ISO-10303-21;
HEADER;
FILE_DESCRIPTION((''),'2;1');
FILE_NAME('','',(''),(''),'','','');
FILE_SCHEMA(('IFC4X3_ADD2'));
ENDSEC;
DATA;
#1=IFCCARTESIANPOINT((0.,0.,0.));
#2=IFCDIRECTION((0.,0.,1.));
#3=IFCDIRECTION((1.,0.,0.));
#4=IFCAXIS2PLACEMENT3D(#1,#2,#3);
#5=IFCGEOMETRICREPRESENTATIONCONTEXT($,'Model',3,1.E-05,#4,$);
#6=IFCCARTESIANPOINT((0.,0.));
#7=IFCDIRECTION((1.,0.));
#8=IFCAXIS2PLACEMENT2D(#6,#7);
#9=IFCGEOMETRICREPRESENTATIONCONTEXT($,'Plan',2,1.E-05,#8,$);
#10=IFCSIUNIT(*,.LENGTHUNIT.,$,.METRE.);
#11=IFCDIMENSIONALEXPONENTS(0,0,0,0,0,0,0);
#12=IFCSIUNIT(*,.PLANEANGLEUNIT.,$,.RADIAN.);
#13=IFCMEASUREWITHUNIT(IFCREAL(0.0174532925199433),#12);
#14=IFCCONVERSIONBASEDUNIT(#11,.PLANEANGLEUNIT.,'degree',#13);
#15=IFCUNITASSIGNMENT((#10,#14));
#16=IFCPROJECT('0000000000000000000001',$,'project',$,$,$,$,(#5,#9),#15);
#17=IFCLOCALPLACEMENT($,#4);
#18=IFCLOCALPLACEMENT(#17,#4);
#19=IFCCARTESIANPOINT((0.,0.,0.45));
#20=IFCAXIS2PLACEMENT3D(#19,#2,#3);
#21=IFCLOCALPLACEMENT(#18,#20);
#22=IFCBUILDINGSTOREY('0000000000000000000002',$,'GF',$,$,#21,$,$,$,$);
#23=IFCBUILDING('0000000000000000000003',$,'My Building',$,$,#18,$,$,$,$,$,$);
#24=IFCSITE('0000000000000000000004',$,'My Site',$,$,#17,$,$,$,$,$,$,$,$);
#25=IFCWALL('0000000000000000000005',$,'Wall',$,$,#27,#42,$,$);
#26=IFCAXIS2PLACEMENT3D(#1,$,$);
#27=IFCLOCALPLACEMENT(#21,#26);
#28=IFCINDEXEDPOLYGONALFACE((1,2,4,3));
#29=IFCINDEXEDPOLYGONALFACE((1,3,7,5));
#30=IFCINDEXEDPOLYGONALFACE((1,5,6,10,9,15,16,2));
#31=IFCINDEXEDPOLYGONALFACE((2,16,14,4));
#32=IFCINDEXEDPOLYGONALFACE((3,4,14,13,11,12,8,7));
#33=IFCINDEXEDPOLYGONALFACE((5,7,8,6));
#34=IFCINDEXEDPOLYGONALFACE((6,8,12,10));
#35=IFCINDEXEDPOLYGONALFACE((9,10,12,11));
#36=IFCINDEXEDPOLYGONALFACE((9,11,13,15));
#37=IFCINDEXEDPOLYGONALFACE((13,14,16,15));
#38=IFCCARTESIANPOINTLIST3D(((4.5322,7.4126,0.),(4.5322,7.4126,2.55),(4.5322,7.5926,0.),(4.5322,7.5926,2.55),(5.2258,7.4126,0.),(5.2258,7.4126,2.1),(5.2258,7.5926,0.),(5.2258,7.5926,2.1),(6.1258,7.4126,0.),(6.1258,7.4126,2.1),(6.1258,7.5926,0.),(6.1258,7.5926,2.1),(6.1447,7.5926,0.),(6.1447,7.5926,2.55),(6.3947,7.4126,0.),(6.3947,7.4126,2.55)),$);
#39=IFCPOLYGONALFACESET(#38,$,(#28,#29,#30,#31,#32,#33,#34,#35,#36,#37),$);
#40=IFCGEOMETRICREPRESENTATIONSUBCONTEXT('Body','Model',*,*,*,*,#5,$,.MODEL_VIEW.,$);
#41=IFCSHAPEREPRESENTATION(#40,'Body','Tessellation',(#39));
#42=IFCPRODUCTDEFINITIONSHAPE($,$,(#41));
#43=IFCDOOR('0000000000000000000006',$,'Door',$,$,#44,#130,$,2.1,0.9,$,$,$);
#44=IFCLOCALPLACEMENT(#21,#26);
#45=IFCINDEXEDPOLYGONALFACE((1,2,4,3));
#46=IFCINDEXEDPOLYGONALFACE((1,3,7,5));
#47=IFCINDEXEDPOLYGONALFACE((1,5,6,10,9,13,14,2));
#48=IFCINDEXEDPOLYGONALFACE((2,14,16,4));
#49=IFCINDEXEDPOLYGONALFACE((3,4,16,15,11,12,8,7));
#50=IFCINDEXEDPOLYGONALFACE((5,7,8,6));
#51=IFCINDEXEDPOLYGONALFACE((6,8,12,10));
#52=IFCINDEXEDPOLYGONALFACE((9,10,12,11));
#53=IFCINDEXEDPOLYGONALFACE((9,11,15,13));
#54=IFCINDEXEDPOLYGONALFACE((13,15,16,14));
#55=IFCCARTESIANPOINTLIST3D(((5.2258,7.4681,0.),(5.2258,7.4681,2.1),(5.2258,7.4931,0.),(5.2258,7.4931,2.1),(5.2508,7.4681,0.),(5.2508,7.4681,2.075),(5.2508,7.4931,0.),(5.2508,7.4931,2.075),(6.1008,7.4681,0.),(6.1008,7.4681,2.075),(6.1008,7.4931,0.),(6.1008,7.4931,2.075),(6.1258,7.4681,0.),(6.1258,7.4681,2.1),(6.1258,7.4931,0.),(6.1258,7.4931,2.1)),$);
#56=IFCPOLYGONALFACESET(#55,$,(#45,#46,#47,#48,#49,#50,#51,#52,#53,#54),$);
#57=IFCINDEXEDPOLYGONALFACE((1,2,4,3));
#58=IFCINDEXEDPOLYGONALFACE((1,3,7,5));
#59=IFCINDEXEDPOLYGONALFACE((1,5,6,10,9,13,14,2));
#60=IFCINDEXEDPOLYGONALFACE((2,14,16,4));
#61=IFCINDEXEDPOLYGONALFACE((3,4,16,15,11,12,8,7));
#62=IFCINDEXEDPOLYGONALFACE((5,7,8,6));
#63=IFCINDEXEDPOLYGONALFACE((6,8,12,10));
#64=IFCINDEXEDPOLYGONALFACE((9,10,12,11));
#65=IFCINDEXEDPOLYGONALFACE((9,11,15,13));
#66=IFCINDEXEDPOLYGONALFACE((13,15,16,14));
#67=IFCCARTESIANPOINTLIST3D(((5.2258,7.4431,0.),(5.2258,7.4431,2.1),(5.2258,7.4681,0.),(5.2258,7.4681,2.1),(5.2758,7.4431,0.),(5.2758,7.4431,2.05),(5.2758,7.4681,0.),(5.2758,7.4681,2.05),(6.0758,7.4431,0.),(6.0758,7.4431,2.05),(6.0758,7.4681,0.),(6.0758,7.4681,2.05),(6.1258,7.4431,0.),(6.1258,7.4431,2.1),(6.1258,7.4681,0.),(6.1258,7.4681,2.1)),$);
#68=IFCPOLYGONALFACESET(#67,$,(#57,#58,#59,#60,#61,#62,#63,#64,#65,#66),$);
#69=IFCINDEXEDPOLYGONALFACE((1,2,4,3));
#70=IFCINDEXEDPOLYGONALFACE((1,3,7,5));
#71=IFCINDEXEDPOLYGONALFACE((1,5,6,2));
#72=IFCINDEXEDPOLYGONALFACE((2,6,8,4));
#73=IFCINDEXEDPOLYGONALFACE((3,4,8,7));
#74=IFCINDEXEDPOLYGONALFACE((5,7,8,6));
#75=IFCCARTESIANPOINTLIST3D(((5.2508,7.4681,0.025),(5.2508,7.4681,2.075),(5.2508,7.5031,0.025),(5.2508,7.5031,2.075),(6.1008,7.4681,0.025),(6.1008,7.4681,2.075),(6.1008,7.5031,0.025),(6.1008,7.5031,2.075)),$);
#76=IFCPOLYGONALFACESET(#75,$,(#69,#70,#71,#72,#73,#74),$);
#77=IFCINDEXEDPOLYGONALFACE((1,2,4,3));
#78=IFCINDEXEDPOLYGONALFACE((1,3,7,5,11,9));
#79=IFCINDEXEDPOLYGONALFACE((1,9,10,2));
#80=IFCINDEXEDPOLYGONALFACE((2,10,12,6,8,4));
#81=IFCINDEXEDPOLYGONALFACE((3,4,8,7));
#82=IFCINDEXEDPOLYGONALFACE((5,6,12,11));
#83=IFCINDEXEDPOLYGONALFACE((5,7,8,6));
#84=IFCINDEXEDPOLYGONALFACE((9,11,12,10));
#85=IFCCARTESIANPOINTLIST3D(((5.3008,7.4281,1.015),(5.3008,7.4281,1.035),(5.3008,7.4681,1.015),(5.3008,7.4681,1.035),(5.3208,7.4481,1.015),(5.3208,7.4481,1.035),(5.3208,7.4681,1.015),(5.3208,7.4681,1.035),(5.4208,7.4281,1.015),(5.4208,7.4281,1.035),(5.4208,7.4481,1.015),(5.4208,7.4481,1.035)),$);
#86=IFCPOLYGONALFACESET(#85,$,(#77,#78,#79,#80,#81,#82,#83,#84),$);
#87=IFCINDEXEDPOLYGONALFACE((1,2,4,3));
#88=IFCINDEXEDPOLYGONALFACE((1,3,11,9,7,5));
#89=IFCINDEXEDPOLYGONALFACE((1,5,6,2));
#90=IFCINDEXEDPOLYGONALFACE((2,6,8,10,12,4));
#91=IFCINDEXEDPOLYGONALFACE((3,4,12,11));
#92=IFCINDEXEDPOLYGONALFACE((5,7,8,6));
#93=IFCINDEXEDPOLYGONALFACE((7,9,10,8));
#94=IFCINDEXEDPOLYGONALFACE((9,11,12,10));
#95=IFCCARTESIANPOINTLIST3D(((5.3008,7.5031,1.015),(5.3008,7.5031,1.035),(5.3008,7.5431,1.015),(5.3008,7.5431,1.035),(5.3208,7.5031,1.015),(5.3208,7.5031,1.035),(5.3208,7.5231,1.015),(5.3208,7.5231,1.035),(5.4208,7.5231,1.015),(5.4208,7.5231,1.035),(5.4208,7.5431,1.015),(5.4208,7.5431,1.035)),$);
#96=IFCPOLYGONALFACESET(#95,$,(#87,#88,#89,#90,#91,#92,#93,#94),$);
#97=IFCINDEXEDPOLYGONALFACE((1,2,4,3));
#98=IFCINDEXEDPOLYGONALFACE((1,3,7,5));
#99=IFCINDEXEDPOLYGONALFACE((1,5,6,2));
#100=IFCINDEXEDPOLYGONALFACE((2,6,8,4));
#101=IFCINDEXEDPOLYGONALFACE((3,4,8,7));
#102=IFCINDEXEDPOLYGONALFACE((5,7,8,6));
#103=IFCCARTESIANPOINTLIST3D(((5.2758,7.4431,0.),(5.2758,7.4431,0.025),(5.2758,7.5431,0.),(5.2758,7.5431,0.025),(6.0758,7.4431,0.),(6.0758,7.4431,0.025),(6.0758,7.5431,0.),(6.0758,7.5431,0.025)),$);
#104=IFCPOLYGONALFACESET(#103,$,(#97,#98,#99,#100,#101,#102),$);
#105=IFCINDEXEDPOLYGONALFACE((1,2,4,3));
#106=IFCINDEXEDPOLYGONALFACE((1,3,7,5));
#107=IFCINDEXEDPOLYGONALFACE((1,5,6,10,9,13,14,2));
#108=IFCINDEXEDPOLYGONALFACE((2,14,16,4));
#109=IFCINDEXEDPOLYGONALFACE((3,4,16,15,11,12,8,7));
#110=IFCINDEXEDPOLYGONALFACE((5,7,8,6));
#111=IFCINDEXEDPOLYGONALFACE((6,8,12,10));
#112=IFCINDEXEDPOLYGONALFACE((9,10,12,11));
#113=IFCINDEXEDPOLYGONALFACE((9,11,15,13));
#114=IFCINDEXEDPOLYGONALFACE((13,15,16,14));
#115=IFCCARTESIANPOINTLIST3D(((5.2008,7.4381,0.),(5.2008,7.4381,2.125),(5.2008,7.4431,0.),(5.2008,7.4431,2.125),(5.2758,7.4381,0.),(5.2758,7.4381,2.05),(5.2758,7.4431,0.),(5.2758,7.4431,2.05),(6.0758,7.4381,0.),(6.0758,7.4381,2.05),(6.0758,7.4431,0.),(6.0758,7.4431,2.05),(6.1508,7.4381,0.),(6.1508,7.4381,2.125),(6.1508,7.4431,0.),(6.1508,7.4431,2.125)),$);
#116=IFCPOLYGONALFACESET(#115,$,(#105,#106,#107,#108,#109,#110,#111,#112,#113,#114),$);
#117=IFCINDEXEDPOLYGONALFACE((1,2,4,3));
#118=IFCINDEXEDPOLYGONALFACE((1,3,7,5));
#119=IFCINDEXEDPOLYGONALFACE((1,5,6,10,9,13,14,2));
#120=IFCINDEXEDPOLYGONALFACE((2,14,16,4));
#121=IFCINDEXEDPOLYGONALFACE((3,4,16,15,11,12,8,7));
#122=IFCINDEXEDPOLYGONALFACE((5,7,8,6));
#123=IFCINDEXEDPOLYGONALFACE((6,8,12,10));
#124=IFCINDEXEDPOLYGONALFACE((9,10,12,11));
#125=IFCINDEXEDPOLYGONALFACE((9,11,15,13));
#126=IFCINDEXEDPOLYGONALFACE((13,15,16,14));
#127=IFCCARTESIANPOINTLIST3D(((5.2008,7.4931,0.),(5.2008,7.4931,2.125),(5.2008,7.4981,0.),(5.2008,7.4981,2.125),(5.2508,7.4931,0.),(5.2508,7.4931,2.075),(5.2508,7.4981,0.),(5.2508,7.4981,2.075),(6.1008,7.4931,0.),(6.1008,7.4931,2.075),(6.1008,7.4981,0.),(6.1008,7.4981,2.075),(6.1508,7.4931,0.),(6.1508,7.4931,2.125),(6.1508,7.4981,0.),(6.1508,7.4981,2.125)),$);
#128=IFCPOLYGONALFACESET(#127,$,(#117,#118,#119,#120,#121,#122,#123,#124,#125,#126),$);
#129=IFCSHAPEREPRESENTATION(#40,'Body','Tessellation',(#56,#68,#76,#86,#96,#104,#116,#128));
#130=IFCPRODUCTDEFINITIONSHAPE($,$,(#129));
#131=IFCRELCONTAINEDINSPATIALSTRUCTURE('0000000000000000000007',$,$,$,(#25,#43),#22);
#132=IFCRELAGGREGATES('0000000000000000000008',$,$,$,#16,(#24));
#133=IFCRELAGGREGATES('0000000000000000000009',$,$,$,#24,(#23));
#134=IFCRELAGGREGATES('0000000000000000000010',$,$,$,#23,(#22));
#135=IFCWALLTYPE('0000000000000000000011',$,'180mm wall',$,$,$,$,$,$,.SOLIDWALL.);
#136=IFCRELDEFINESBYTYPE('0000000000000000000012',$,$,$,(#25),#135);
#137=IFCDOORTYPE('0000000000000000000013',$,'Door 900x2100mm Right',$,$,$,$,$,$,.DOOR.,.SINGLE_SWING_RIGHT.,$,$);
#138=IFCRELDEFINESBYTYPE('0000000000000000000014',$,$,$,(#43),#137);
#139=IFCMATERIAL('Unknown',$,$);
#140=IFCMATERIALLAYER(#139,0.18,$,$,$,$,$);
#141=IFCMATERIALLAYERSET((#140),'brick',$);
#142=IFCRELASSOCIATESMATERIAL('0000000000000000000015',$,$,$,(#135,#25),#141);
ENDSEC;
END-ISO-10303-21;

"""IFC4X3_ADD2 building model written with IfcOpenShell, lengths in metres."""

from ifc_helpers import new_model, entity, si_unit, converted_unit, frame, origin_with_axes, origin_2d_with_axis, place, context, subcontext, project, spatial, line, indexed_curve, outline, extrude, shape, source, transform, mapped, material, layer, layer_set, layer_usage, type_object, type_shapes, element, fill, save


model = new_model("IFC4X3_ADD2")

# Units and contexts
model_context = context("Model", 3, precision=1e-05, world=origin_with_axes())
plan_context = context("Plan", 2, precision=1e-05, world=origin_2d_with_axis())
body_context_1 = subcontext(model_context, "Body", "Model", "MODEL_VIEW")
body_context_2 = subcontext(plan_context, "Body", "Plan", "PLAN_VIEW")
ifc_project = project(units=[si_unit("LENGTHUNIT", "METRE"), converted_unit("PLANEANGLEUNIT", "degree", entity("IfcReal", 0.0174532925199433), si_unit("PLANEANGLEUNIT", "RADIAN"), dimensions=[0, 0, 0, 0, 0, 0, 0])], contexts=[model_context, plan_context])

# Site, building, storey
site_placement = place(None, origin_with_axes())
site = spatial("IfcSite", under=ifc_project, at=site_placement, Name="My Site")
building_placement = place(site_placement, origin_with_axes())
building = spatial("IfcBuilding", under=site, at=building_placement, Name="My Building")
storey_placement = place(building_placement, frame((0.0, 0.0, 0.45), z_axis=(0.0, 0.0, 1.0), x_axis=(1.0, 0.0, 0.0)))
storey = spatial("IfcBuildingStorey", under=building, at=storey_placement, Name="GF")

# Shared definitions
ifc_material_1 = material(Name="Unknown")

# Shared definitions
shared_shape_1 = source(origin_with_axes(), body_context_1, "Body", "SolidModel", [
    extrude(outline(indexed_curve([(0.0, 0.0), (0.9, 0.0), (0.9, 2.1), (0.0, 2.1)], segments=[line(1, 2, 3, 4, 1)])), frame((0.0, -0.6, 0.0), z_axis=(0.0, -1.0, 0.0), x_axis=(1.0, 0.0, 0.0)), (0.0, 0.0, -1.0), 1.2),
])
door_type_1 = type_object("IfcDoorType", Name="Door 900x2100mm Right", OperationType="SINGLE_SWING_RIGHT", PredefinedType="DOOR")
shared_shape_2 = source(origin_with_axes(), body_context_1, "Body", "SweptSolid", [
    extrude(outline(indexed_curve([(0.0, 0.0), (0.0, 2.1), (0.9, 2.1), (0.9, 0.0), (0.875, 0.0), (0.875, 2.075), (0.025, 2.075), (0.025, 0.0)], segments=[line(1, 2, 3, 4, 5, 6, 7, 8, 1)])), frame((0.0, 0.025, 0.0), z_axis=(0.0, -1.0, 0.0), x_axis=(1.0, 0.0, 0.0)), (0.0, 0.0, -1.0), 0.025),
    extrude(outline(indexed_curve([(0.0, 0.0), (0.0, 2.1), (0.9, 2.1), (0.9, 0.0), (0.85, 0.0), (0.85, 2.05), (0.05, 2.05), (0.05, 0.0)], segments=[line(1, 2, 3, 4, 5, 6, 7, 8, 1)])), frame((0.0, 0.0, 0.0), z_axis=(0.0, -1.0, 0.0), x_axis=(1.0, 0.0, 0.0)), (0.0, 0.0, -1.0), 0.025),
    extrude(outline(indexed_curve([(0.0, 0.0), (0.85, 0.0), (0.85, 0.035), (0.0, 0.035)], segments=[line(1, 2, 3, 4, 1)])), frame((0.025, 0.025, 0.025), z_axis=(0.0, 0.0, 1.0), x_axis=(1.0, 0.0, 0.0)), (0.0, 0.0, 1.0), 2.05),
    extrude(outline(indexed_curve([(0.0, 0.0), (0.0, -0.04), (0.12, -0.04), (0.12, -0.02), (0.02, -0.02), (0.02, 0.0)], segments=[line(1, 2, 3, 4, 5, 6, 1)])), frame((0.075, 0.025, 1.015), z_axis=(0.0, 0.0, 1.0), x_axis=(1.0, 0.0, 0.0)), (0.0, 0.0, 1.0), 0.02),
    extrude(outline(indexed_curve([(0.0, 0.0), (0.0, 0.04), (0.12, 0.04), (0.12, 0.02), (0.02, 0.02), (0.02, 0.0)], segments=[line(1, 2, 3, 4, 5, 6, 1)])), frame((0.075, 0.06, 1.015), z_axis=(0.0, 0.0, 1.0), x_axis=(1.0, 0.0, 0.0)), (0.0, 0.0, 1.0), 0.02),
    extrude(outline(indexed_curve([(0.0, 0.0), (0.8, 0.0), (0.8, 0.1), (0.0, 0.1)], segments=[line(1, 2, 3, 4, 1)])), frame((0.05, 0.0, 0.0), z_axis=(0.0, 0.0, 1.0), x_axis=(1.0, 0.0, 0.0)), (0.0, 0.0, 1.0), 0.025),
    extrude(outline(indexed_curve([(0.0, 0.0), (0.0, 2.125), (0.95, 2.125), (0.95, 0.0), (0.875, 0.0), (0.875, 2.05), (0.075, 2.05), (0.075, 0.0)], segments=[line(1, 2, 3, 4, 5, 6, 7, 8, 1)])), frame((-0.025, -0.005, 0.0), z_axis=(0.0, -1.0, 0.0), x_axis=(1.0, 0.0, 0.0)), (0.0, 0.0, -1.0), 0.005),
    extrude(outline(indexed_curve([(0.0, 0.0), (0.0, 2.125), (0.95, 2.125), (0.95, 0.0), (0.9, 0.0), (0.9, 2.075), (0.05, 2.075), (0.05, 0.0)], segments=[line(1, 2, 3, 4, 5, 6, 7, 8, 1)])), frame((-0.025, 0.05, 0.0), z_axis=(0.0, -1.0, 0.0), x_axis=(1.0, 0.0, 0.0)), (0.0, 0.0, -1.0), 0.005),
])
shared_shape_3 = source(origin_with_axes(), body_context_2, "Body", "Curve2D", [
    entity("IfcIndexedPolyCurve", entity("IfcCartesianPointList2D", [[0.0, 0.0], [0.0, 0.05], [0.025, 0.05], [0.025, 0.025], [0.05, 0.025], [0.05, 0.0]]), [entity("IfcLineIndex", [1, 2, 3, 4, 5, 6, 1])]),
    entity("IfcIndexedPolyCurve", entity("IfcCartesianPointList2D", [[0.9, 0.0], [0.9, 0.05], [0.875, 0.05], [0.875, 0.025], [0.85, 0.025], [0.85, 0.0]]), [entity("IfcLineIndex", [1, 2, 3, 4, 5, 6, 1])]),
    entity("IfcTrimmedCurve", entity("IfcEllipse", entity("IfcAxis2Placement2D", entity("IfcCartesianPoint", [0.84, 0.05]), entity("IfcDirection", [1.0, 0.0])), 0.815, 0.85), [entity("IfcCartesianPoint", [0.84, 0.9])], [entity("IfcCartesianPoint", [0.025, 0.05])], True, "CARTESIAN"),
    entity("IfcIndexedPolyCurve", entity("IfcCartesianPointList2D", [[0.875, 0.05], [0.84, 0.05], [0.84, 0.9], [0.875, 0.9]]), [entity("IfcLineIndex", [1, 2, 3, 4, 1])]),
])
type_shapes(door_type_1, [shared_shape_2, shared_shape_3])

# Shared definitions
ifc_layer_1 = layer(ifc_material_1, 0.18)
ifc_layer_set_1 = layer_set([ifc_layer_1], Name="brick")
wall_type_1 = type_object("IfcWallType", Name="180mm wall", PredefinedType="SOLIDWALL", material=ifc_layer_set_1)

# Wall, opening, door
ifc_layer_usage_1 = layer_usage(ifc_layer_set_1, "AXIS2", "POSITIVE", 0.0)
wall_1_placement = place(storey_placement, frame((6.3947, 7.5926, 0.0), z_axis=(0.0, 0.0, 1.0), x_axis=(-1.0, 0.0, 0.0)))
wall_1 = element("IfcWall", 1, at=wall_1_placement, inside=storey, type_object=wall_type_1, material=ifc_layer_usage_1, Name="Wall", context=body_context_1, shape_type="SweptSolid", body=[
    extrude(outline(indexed_curve([(0.25, 0.0), (0.0, 0.18), (1.8625, 0.18), (1.8625, 0.0)], segments=[line(1, 2, 3, 4, 1)])), origin_with_axes(), (0.0, 0.0, 1.0), 2.55),
])
opening_1_placement = place(wall_1_placement, frame((1.1688, 0.1495, 0.0), z_axis=(0.0, 0.0, 1.0), x_axis=(-1.0, 0.0, 0.0)))
opening_1 = element("IfcOpeningElement", 2, at=opening_1_placement, cuts=wall_1, PredefinedType="OPENING", context=body_context_1, shape_type="MappedRepresentation", body=[
    mapped(shared_shape_1, transform((0.0, 0.0, 0.0), x_axis=(1.0, 0.0, 0.0), y_axis=(0.0, 1.0, 0.0), z_axis=(0.0, 0.0, 1.0), scale=1.0)),
])
door_1_placement = place(opening_1_placement, frame((0.0, 0.0, 0.0), z_axis=(0.0, 0.0, 1.0), x_axis=(1.0, 0.0, 0.0)))
door_1 = element("IfcDoor", 3, at=door_1_placement, inside=storey, type_object=door_type_1, Name="Door", OverallHeight=2.1, OverallWidth=0.9, shapes=[
    shape(body_context_1, "Body", "MappedRepresentation", [mapped(shared_shape_2, transform((0.0, 0.0, 0.0), x_axis=(1.0, 0.0, 0.0), y_axis=(0.0, 1.0, 0.0), z_axis=(0.0, 0.0, 1.0), scale=1.0))]),
    shape(body_context_2, "Body", "MappedRepresentation", [mapped(shared_shape_3, transform((0.0, 0.0, 0.0), x_axis=(1.0, 0.0, 0.0), y_axis=(0.0, 1.0, 0.0), z_axis=(0.0, 0.0, 1.0), scale=1.0))]),
])
fill(opening_1, door_1)

save(model, "model.ifc")
